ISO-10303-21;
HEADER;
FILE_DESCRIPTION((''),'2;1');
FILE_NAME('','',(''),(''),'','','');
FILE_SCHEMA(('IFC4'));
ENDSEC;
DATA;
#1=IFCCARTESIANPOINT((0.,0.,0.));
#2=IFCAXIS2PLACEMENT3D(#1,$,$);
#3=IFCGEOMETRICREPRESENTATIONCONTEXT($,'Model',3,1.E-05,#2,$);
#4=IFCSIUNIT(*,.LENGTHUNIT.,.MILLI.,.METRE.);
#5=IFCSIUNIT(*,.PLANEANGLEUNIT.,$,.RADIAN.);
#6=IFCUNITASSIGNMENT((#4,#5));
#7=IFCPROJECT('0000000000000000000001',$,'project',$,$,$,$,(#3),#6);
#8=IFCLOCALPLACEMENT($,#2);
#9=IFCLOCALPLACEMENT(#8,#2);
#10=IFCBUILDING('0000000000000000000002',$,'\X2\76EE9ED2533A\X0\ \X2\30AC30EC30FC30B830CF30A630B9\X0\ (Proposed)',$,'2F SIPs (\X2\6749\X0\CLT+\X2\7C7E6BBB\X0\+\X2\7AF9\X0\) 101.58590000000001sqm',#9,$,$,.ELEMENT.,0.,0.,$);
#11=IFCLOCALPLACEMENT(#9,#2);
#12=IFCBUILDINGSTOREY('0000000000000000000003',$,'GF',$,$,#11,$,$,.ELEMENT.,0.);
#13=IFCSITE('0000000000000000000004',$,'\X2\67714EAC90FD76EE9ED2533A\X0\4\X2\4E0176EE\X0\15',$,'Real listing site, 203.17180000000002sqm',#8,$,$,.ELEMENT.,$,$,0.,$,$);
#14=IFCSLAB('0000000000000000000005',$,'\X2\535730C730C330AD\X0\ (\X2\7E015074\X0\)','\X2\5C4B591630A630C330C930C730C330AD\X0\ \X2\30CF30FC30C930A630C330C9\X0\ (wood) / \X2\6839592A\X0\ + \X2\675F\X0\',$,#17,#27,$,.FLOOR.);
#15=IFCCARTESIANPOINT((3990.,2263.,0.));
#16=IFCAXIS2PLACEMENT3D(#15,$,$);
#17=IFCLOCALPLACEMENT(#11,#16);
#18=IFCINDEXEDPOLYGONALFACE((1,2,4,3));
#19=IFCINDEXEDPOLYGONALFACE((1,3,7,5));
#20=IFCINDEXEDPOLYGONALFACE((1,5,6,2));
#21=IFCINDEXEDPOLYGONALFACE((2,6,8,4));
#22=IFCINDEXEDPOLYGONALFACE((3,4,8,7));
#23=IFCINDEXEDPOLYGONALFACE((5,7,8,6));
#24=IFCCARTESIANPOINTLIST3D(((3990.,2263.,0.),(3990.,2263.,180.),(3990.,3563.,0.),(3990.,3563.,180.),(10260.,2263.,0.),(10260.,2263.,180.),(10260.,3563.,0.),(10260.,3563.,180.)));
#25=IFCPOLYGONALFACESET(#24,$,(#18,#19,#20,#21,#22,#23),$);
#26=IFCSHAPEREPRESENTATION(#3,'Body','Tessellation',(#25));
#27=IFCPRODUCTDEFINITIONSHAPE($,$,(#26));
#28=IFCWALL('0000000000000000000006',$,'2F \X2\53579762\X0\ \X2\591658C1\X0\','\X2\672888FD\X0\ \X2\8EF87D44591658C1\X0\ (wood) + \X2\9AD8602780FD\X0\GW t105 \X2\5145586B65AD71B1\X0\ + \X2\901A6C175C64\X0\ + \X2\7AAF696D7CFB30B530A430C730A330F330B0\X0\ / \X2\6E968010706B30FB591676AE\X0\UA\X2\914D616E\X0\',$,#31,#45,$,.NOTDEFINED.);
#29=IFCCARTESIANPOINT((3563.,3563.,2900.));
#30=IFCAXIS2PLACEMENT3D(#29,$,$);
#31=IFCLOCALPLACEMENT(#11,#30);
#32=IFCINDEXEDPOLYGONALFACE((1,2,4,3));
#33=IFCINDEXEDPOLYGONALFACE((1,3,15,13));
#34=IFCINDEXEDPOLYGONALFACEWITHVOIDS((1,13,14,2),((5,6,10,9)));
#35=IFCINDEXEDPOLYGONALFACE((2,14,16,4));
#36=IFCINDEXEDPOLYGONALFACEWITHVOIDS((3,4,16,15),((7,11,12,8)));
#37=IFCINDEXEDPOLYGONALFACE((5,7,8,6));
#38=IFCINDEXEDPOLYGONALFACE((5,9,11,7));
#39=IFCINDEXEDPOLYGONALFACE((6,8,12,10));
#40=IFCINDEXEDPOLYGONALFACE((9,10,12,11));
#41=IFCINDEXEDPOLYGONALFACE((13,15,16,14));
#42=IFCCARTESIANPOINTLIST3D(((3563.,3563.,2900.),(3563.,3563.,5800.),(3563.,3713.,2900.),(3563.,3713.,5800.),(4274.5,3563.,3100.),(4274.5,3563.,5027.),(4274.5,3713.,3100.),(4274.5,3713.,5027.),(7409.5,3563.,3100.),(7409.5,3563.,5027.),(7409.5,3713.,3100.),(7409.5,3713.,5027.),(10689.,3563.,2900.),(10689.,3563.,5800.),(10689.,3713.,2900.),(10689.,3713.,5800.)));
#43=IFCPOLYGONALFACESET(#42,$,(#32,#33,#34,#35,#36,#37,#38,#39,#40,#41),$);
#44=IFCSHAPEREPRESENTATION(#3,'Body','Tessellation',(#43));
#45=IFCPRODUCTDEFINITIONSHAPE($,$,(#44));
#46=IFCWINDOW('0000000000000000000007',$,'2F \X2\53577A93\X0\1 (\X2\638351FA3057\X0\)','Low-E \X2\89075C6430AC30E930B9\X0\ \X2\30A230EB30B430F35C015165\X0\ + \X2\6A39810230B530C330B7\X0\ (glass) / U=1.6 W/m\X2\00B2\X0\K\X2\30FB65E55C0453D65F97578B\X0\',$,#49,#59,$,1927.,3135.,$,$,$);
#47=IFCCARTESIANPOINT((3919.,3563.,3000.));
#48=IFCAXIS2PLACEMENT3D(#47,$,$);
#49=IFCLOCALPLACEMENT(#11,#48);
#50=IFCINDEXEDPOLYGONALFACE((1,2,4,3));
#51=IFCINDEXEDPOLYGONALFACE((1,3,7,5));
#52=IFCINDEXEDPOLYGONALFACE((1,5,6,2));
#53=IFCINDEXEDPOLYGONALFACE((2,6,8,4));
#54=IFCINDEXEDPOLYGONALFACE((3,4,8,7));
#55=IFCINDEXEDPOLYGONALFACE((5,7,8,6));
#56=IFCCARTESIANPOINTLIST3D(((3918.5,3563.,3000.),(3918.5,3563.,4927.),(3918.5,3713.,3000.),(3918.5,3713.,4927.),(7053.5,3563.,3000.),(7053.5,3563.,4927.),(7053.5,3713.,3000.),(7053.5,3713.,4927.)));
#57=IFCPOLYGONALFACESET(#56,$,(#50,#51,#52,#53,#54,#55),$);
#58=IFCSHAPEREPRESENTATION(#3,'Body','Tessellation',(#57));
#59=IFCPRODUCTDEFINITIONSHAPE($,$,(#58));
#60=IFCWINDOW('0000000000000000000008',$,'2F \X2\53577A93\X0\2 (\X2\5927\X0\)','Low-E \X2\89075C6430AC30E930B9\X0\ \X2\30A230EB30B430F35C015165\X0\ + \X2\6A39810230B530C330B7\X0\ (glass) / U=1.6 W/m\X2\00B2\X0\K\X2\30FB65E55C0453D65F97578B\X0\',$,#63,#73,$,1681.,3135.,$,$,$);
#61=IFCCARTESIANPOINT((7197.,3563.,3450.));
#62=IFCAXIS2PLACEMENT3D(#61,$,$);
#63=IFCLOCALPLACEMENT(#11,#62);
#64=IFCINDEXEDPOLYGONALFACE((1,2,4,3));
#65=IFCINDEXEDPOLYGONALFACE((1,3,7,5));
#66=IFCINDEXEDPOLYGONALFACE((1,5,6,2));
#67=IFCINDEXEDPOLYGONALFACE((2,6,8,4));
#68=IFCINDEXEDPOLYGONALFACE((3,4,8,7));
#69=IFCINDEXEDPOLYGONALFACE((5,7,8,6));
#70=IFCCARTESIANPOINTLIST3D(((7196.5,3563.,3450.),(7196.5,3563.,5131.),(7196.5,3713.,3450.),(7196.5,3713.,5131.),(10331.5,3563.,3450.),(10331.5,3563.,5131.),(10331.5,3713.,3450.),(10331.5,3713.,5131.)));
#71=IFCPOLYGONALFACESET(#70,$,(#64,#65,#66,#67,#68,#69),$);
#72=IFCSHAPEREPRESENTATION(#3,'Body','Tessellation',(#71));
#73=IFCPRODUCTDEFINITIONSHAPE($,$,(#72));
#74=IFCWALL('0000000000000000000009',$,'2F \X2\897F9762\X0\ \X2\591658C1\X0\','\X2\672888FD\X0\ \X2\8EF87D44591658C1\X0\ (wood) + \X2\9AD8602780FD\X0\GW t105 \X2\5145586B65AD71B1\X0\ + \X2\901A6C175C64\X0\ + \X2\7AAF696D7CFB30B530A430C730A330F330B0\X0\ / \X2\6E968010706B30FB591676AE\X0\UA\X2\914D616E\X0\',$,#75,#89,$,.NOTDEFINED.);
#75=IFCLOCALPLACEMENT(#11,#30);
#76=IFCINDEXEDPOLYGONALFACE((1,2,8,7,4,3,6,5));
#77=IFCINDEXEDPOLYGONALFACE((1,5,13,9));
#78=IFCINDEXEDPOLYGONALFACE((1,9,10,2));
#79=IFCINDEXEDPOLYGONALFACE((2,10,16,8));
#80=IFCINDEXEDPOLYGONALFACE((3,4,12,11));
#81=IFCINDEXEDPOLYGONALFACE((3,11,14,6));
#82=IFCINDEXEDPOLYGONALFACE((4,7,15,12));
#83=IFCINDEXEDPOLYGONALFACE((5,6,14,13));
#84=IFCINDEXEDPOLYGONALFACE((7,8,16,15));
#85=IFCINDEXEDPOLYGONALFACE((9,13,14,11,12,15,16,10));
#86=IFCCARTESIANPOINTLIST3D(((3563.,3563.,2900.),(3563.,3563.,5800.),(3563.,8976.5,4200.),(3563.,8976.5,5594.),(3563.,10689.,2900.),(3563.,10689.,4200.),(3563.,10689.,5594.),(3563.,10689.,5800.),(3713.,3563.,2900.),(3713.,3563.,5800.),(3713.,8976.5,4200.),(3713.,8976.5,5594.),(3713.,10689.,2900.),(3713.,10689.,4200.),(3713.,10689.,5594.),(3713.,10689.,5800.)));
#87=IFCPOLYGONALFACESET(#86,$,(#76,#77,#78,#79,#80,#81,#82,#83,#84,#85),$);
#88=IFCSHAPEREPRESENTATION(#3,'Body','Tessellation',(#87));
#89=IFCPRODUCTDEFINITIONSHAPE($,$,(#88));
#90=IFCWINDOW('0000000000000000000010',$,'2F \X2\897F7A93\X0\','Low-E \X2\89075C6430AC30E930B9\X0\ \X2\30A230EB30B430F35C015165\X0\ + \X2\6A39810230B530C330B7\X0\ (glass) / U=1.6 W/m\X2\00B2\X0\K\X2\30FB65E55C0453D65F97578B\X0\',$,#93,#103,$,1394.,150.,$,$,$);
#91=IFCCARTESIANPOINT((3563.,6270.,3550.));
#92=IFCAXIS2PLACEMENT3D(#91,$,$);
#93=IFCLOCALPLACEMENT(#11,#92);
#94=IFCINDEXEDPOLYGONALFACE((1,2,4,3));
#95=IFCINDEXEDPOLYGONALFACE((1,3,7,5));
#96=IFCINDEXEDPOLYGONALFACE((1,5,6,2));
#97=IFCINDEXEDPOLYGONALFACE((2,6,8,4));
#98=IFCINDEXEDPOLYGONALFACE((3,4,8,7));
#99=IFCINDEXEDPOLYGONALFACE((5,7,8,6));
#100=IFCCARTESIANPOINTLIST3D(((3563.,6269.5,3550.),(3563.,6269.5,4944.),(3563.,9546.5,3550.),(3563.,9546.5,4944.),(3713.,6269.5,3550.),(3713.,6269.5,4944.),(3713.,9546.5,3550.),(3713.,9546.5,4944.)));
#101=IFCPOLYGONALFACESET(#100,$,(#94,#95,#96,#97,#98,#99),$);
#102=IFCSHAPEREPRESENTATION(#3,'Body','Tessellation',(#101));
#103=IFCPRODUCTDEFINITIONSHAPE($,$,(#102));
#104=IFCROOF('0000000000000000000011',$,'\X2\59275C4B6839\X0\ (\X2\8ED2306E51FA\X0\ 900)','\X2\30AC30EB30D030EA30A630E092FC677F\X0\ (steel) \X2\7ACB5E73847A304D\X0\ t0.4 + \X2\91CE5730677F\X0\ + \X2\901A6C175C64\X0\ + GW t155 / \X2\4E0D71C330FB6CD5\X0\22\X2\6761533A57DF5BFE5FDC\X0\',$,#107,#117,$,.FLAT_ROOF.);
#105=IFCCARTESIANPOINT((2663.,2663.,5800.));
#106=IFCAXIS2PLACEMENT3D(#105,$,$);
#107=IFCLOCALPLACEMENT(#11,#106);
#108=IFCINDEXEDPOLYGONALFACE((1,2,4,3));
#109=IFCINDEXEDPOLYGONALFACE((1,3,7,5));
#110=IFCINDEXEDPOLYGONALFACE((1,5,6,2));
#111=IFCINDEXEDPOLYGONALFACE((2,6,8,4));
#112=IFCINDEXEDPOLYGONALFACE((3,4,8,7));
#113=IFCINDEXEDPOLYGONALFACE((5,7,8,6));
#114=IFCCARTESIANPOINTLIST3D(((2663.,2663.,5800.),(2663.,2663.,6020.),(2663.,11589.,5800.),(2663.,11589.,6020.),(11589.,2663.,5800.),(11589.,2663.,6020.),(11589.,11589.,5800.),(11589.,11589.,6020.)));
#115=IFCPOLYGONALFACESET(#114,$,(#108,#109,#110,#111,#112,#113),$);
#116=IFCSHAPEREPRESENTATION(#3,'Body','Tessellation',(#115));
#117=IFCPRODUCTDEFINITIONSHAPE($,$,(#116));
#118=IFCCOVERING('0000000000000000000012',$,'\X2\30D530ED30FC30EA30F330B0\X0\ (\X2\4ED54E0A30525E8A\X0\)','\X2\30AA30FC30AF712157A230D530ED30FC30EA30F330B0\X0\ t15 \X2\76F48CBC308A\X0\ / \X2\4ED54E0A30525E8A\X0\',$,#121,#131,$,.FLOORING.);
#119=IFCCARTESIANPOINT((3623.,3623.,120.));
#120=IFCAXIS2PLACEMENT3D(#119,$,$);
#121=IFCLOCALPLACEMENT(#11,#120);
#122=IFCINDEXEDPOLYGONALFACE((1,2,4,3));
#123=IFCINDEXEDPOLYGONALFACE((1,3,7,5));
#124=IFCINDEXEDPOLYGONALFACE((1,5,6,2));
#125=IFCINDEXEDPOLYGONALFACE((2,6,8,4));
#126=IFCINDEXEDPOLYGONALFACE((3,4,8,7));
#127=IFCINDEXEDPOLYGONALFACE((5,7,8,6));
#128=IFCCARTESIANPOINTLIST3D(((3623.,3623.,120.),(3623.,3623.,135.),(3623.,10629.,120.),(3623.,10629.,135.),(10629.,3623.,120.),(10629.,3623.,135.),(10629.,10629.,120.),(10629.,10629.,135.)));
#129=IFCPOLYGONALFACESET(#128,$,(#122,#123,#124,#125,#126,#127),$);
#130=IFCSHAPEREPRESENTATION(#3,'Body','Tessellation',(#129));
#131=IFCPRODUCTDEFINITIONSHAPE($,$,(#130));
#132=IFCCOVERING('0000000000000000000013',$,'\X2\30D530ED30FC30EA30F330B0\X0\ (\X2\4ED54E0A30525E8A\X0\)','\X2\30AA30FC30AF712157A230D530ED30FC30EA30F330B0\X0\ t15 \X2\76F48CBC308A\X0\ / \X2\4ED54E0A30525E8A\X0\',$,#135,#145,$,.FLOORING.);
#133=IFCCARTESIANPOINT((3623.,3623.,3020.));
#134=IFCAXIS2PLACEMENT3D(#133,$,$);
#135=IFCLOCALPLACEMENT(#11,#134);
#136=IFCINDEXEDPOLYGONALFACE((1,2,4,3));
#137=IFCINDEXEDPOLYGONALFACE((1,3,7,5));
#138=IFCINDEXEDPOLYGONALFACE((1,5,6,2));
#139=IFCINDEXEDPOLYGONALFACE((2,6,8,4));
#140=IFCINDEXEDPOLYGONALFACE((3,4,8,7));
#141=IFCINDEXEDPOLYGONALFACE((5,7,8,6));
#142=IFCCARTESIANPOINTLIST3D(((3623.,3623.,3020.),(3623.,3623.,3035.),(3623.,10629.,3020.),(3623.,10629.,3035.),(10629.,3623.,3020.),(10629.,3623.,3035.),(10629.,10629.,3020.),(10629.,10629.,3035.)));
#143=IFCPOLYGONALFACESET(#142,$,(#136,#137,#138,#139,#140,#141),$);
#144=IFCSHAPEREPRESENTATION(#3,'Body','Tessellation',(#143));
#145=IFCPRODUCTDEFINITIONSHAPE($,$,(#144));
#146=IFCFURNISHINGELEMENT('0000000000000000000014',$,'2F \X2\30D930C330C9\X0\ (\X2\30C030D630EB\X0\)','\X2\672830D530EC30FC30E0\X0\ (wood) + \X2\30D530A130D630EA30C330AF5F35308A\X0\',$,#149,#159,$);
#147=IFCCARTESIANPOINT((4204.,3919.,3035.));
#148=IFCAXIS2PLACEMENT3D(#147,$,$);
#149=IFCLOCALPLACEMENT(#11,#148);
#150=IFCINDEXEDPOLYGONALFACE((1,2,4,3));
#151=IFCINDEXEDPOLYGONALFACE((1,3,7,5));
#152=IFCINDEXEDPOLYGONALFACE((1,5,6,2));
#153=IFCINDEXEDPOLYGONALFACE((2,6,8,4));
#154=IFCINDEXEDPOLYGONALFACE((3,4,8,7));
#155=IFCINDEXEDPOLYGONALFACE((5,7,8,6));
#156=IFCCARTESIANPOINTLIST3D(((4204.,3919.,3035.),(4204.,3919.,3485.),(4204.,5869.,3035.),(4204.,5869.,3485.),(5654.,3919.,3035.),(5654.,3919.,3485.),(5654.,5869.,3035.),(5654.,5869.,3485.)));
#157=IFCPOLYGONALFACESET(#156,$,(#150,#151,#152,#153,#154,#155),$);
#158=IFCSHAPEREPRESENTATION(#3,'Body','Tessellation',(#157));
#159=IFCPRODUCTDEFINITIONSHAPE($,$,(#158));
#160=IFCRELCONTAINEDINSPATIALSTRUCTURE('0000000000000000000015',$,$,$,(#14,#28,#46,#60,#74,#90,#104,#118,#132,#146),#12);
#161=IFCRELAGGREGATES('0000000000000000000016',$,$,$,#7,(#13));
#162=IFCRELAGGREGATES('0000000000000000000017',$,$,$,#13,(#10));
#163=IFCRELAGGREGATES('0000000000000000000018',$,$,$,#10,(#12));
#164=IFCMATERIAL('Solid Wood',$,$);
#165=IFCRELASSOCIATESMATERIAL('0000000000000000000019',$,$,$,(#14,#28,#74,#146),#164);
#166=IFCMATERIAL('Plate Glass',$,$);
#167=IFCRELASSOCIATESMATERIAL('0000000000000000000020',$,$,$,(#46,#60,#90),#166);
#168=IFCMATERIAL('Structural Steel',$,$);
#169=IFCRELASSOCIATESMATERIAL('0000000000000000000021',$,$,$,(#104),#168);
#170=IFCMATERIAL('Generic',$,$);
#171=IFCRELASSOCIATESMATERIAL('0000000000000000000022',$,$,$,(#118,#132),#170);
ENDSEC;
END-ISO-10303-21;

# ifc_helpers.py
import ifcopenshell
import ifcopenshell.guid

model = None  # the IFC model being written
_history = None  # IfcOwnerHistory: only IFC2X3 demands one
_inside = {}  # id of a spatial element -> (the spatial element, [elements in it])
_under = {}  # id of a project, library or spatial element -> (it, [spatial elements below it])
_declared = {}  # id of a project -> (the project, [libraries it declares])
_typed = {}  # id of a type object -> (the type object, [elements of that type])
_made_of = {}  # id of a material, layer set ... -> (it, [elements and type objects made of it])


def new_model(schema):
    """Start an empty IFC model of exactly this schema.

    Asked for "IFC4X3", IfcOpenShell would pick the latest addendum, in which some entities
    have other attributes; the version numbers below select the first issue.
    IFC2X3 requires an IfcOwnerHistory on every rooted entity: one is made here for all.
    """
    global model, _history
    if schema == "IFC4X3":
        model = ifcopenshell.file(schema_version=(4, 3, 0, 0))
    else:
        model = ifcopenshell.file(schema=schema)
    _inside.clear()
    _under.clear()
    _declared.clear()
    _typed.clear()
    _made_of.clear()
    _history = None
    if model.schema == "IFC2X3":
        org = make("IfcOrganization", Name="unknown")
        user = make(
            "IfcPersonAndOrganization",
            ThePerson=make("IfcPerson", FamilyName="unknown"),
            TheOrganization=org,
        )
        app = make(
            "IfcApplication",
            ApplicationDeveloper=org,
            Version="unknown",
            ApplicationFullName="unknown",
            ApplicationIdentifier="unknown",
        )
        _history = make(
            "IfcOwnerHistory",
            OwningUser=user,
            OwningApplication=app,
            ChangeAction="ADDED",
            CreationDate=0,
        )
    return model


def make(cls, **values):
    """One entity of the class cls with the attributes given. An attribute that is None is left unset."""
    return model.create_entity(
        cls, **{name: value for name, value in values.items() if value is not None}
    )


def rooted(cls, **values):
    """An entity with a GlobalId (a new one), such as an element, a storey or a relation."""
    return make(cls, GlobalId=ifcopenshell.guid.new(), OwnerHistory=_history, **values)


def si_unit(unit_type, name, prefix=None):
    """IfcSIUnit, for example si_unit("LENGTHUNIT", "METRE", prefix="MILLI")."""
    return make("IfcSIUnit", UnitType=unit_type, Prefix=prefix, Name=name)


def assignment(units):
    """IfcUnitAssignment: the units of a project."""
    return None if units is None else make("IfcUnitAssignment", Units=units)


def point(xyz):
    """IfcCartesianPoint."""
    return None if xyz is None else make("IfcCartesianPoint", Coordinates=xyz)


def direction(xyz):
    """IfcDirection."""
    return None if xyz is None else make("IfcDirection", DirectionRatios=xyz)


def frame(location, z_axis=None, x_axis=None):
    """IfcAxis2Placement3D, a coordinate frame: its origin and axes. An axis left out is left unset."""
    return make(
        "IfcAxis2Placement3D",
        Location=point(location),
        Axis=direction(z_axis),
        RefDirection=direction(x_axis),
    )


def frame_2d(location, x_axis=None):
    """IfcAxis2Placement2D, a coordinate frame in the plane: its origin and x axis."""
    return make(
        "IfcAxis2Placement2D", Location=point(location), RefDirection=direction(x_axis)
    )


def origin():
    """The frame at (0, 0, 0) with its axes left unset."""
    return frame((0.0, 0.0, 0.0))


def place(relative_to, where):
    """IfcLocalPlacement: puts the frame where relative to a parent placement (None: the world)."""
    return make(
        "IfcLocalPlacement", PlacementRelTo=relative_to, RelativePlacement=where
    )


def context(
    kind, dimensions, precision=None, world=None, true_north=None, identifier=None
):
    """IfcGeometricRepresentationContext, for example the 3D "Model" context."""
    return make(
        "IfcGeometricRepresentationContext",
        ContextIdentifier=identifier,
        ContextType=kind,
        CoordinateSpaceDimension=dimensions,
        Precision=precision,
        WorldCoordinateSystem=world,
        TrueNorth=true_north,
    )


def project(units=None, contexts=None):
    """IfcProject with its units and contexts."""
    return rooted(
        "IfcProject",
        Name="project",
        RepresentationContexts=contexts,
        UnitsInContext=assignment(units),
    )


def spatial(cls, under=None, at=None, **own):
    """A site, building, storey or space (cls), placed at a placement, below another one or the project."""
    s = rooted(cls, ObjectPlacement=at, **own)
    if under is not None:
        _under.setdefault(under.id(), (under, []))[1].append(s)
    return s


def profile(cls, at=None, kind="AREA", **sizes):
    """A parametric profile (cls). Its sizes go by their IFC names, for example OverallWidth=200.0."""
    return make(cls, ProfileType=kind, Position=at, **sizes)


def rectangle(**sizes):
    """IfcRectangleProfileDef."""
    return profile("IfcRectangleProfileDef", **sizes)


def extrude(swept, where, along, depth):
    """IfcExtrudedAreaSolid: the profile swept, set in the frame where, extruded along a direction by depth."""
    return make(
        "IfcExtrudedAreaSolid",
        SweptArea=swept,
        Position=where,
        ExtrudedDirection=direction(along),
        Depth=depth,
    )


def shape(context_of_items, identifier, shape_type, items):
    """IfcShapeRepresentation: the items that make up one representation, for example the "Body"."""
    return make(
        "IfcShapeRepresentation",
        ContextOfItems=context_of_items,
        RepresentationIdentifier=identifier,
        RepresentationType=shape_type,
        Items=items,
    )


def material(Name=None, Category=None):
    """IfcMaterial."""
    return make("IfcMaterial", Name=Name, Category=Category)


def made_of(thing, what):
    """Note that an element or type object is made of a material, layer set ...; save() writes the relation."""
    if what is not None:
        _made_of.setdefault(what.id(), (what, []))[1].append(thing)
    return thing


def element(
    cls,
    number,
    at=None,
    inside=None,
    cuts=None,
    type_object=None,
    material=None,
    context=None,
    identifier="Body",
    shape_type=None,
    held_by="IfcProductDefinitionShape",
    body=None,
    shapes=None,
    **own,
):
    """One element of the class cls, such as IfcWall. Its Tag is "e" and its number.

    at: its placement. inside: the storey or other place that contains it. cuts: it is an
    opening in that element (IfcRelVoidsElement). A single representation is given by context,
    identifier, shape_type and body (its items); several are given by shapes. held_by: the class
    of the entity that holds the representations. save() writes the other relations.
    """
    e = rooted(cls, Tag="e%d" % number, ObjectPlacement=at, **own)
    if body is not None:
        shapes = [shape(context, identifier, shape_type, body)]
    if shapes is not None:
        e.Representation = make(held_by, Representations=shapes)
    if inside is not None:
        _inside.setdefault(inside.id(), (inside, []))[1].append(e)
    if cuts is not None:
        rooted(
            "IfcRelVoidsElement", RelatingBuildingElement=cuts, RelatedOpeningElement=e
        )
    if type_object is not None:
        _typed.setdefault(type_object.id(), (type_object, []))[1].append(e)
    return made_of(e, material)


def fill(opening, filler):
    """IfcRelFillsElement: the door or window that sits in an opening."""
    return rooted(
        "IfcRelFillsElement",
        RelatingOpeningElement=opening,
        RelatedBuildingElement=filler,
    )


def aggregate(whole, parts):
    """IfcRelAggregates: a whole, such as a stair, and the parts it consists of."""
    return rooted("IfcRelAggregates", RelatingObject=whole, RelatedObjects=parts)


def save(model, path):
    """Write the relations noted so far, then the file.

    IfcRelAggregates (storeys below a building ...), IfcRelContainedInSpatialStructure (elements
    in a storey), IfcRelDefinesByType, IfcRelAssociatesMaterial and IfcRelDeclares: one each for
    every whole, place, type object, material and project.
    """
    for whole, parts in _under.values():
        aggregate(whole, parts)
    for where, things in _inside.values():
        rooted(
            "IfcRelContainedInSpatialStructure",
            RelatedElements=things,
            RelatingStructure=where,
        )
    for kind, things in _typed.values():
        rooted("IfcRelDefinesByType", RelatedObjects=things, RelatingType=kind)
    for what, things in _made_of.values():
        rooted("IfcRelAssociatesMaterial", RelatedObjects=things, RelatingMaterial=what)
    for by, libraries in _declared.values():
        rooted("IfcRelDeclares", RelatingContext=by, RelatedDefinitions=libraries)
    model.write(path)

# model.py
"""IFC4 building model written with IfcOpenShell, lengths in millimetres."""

from ifc_helpers import new_model, si_unit, frame, frame_2d, origin, place, context, project, spatial, rectangle, extrude, material, element, fill, save


model = new_model("IFC4")

# Units and contexts
model_context = context("Model", 3, precision=1e-05, world=origin())
ifc_project = project(units=[si_unit("LENGTHUNIT", "METRE", prefix="MILLI"), si_unit("PLANEANGLEUNIT", "RADIAN")], contexts=[model_context])

# Site, building, storey
site_placement = place(None, origin())
site = spatial("IfcSite", under=ifc_project, at=site_placement, Name="東京都目黒区4丁目15", ObjectType="Real listing site, 203.17180000000002sqm", CompositionType="ELEMENT", RefElevation=0.0)
building_placement = place(site_placement, origin())
building = spatial("IfcBuilding", under=site, at=building_placement, Name="目黒区 ガレージハウス (Proposed)", ObjectType="2F SIPs (杉CLT+籾殻+竹) 101.58590000000001sqm", CompositionType="ELEMENT", ElevationOfRefHeight=0.0, ElevationOfTerrain=0.0)
storey_placement = place(building_placement, origin())
storey = spatial("IfcBuildingStorey", under=building, at=storey_placement, Name="GF", CompositionType="ELEMENT", Elevation=0.0)

# Slab
ifc_material_1 = material(Name="Solid Wood")
slab_1_placement = place(storey_placement, frame((3990.0, 2263.0, 0.0)))
element("IfcSlab", 1, at=slab_1_placement, inside=storey, material=ifc_material_1, Name="南デッキ (縁側)", Description="屋外ウッドデッキ ハードウッド (wood) / 根太 + 束", PredefinedType="FLOOR", context=model_context, shape_type="SweptSolid", body=[
    extrude(rectangle(XDim=6270.0, YDim=1300.0, at=frame_2d((3135.0, 650.0))), frame((3990.0, 2263.0, 0.0)), (0.0, 0.0, 1.0), 180.0),
])

# Shared definitions
ifc_material_2 = material(Name="Plate Glass")

# Wall, openings, windows
wall_1_placement = place(storey_placement, frame((3563.0, 3563.0, 2900.0)))
wall_1 = element("IfcWall", 2, at=wall_1_placement, inside=storey, material=ifc_material_1, Name="2F 南面 外壁", Description="木製 軸組外壁 (wood) + 高性能GW t105 充填断熱 + 通気層 + 窯業系サイディング / 準耐火・外皮UA配慮", PredefinedType="NOTDEFINED", context=model_context, shape_type="SweptSolid", body=[
    extrude(rectangle(XDim=7126.0, YDim=150.0, at=frame_2d((3563.0, 75.0))), frame((3563.0, 3563.0, 2900.0)), (0.0, 0.0, 1.0), 2900.0),
])
opening_1_placement = place(storey_placement, frame((3919.0, 3563.0, 3000.0)))
opening_1 = element("IfcOpeningElement", 3, at=opening_1_placement, cuts=wall_1, PredefinedType="NOTDEFINED", context=model_context, shape_type="SweptSolid", body=[
    extrude(rectangle(XDim=3135.0, YDim=150.0, at=frame_2d((1567.0, 75.0))), frame((3919.0, 3563.0, 3000.0)), (0.0, 0.0, 1.0), 1927.0),
])
opening_2_placement = place(storey_placement, frame((7197.0, 3563.0, 3450.0)))
opening_2 = element("IfcOpeningElement", 4, at=opening_2_placement, cuts=wall_1, PredefinedType="NOTDEFINED", context=model_context, shape_type="SweptSolid", body=[
    extrude(rectangle(XDim=3135.0, YDim=150.0, at=frame_2d((1567.0, 75.0))), frame((7197.0, 3563.0, 3450.0)), (0.0, 0.0, 1.0), 1681.0),
])
window_1_placement = place(storey_placement, frame((3919.0, 3563.0, 3000.0)))
window_1 = element("IfcWindow", 5, at=window_1_placement, inside=storey, material=ifc_material_2, Name="2F 南窓1 (掃出し)", Description="Low-E 複層ガラス アルゴン封入 + 樹脂サッシ (glass) / U=1.6 W/m²K・日射取得型", OverallHeight=1927.0, OverallWidth=3135.0, context=model_context, shape_type="SweptSolid", body=[
    extrude(rectangle(XDim=3135.0, YDim=150.0, at=frame_2d((1567.0, 75.0))), frame((3919.0, 3563.0, 3000.0)), (0.0, 0.0, 1.0), 1927.0),
])
fill(opening_1, window_1)
window_2_placement = place(storey_placement, frame((7197.0, 3563.0, 3450.0)))
window_2 = element("IfcWindow", 6, at=window_2_placement, inside=storey, material=ifc_material_2, Name="2F 南窓2 (大)", Description="Low-E 複層ガラス アルゴン封入 + 樹脂サッシ (glass) / U=1.6 W/m²K・日射取得型", OverallHeight=1681.0, OverallWidth=3135.0, context=model_context, shape_type="SweptSolid", body=[
    extrude(rectangle(XDim=3135.0, YDim=150.0, at=frame_2d((1567.0, 75.0))), frame((7197.0, 3563.0, 3450.0)), (0.0, 0.0, 1.0), 1681.0),
])
fill(opening_2, window_2)

# Wall, opening, window
wall_2_placement = place(storey_placement, frame((3563.0, 3563.0, 2900.0)))
wall_2 = element("IfcWall", 7, at=wall_2_placement, inside=storey, material=ifc_material_1, Name="2F 西面 外壁", Description="木製 軸組外壁 (wood) + 高性能GW t105 充填断熱 + 通気層 + 窯業系サイディング / 準耐火・外皮UA配慮", PredefinedType="NOTDEFINED", context=model_context, shape_type="SweptSolid", body=[
    extrude(rectangle(XDim=150.0, YDim=7126.0, at=frame_2d((75.0, 3563.0))), frame((3563.0, 3563.0, 2900.0)), (0.0, 0.0, 1.0), 2900.0),
])
opening_3_placement = place(storey_placement, frame((3563.0, 6270.0, 3550.0)))
opening_3 = element("IfcOpeningElement", 8, at=opening_3_placement, cuts=wall_2, PredefinedType="NOTDEFINED", context=model_context, shape_type="SweptSolid", body=[
    extrude(rectangle(XDim=150.0, YDim=3277.0, at=frame_2d((75.0, 1638.0))), frame((3563.0, 6270.0, 3550.0)), (0.0, 0.0, 1.0), 1394.0),
])
window_3_placement = place(storey_placement, frame((3563.0, 6270.0, 3550.0)))
window_3 = element("IfcWindow", 9, at=window_3_placement, inside=storey, material=ifc_material_2, Name="2F 西窓", Description="Low-E 複層ガラス アルゴン封入 + 樹脂サッシ (glass) / U=1.6 W/m²K・日射取得型", OverallHeight=1394.0, OverallWidth=150.0, context=model_context, shape_type="SweptSolid", body=[
    extrude(rectangle(XDim=150.0, YDim=3277.0, at=frame_2d((75.0, 1638.0))), frame((3563.0, 6270.0, 3550.0)), (0.0, 0.0, 1.0), 1394.0),
])
fill(opening_3, window_3)

# Roof
ifc_material_3 = material(Name="Structural Steel")
roof_placement = place(storey_placement, frame((2663.0, 2663.0, 5800.0)))
element("IfcRoof", 10, at=roof_placement, inside=storey, material=ifc_material_3, Name="大屋根 (軒の出 900)", Description="ガルバリウム鋼板 (steel) 立平葺き t0.4 + 野地板 + 通気層 + GW t155 / 不燃・法22条区域対応", PredefinedType="FLAT_ROOF", context=model_context, shape_type="SweptSolid", body=[
    extrude(rectangle(XDim=8926.0, YDim=8926.0, at=frame_2d((4463.0, 4463.0))), frame((2663.0, 2663.0, 5800.0)), (0.0, 0.0, 1.0), 220.0),
])

# Coverings
ifc_material_4 = material(Name="Generic")
covering_1_placement = place(storey_placement, frame((3623.0, 3623.0, 120.0)))
element("IfcCovering", 11, at=covering_1_placement, inside=storey, material=ifc_material_4, Name="フローリング (仕上げ床)", Description="オーク無垢フローリング t15 直貼り / 仕上げ床", PredefinedType="FLOORING", context=model_context, shape_type="SweptSolid", body=[
    extrude(rectangle(XDim=7006.0, YDim=7006.0, at=frame_2d((3503.0, 3503.0))), frame((3623.0, 3623.0, 120.0)), (0.0, 0.0, 1.0), 15.0),
])
covering_2_placement = place(storey_placement, frame((3623.0, 3623.0, 3020.0)))
element("IfcCovering", 12, at=covering_2_placement, inside=storey, material=ifc_material_4, Name="フローリング (仕上げ床)", Description="オーク無垢フローリング t15 直貼り / 仕上げ床", PredefinedType="FLOORING", context=model_context, shape_type="SweptSolid", body=[
    extrude(rectangle(XDim=7006.0, YDim=7006.0, at=frame_2d((3503.0, 3503.0))), frame((3623.0, 3623.0, 3020.0)), (0.0, 0.0, 1.0), 15.0),
])

# Furnishing element
furnishing_placement = place(storey_placement, frame((4204.0, 3919.0, 3035.0)))
element("IfcFurnishingElement", 13, at=furnishing_placement, inside=storey, material=ifc_material_1, Name="2F ベッド (ダブル)", Description="木フレーム (wood) + ファブリック張り", context=model_context, shape_type="SweptSolid", body=[
    extrude(rectangle(XDim=1450.0, YDim=1950.0, at=frame_2d((725.0, 975.0))), frame((4204.0, 3919.0, 3035.0)), (0.0, 0.0, 1.0), 450.0),
])

save(model, "model.ifc")
